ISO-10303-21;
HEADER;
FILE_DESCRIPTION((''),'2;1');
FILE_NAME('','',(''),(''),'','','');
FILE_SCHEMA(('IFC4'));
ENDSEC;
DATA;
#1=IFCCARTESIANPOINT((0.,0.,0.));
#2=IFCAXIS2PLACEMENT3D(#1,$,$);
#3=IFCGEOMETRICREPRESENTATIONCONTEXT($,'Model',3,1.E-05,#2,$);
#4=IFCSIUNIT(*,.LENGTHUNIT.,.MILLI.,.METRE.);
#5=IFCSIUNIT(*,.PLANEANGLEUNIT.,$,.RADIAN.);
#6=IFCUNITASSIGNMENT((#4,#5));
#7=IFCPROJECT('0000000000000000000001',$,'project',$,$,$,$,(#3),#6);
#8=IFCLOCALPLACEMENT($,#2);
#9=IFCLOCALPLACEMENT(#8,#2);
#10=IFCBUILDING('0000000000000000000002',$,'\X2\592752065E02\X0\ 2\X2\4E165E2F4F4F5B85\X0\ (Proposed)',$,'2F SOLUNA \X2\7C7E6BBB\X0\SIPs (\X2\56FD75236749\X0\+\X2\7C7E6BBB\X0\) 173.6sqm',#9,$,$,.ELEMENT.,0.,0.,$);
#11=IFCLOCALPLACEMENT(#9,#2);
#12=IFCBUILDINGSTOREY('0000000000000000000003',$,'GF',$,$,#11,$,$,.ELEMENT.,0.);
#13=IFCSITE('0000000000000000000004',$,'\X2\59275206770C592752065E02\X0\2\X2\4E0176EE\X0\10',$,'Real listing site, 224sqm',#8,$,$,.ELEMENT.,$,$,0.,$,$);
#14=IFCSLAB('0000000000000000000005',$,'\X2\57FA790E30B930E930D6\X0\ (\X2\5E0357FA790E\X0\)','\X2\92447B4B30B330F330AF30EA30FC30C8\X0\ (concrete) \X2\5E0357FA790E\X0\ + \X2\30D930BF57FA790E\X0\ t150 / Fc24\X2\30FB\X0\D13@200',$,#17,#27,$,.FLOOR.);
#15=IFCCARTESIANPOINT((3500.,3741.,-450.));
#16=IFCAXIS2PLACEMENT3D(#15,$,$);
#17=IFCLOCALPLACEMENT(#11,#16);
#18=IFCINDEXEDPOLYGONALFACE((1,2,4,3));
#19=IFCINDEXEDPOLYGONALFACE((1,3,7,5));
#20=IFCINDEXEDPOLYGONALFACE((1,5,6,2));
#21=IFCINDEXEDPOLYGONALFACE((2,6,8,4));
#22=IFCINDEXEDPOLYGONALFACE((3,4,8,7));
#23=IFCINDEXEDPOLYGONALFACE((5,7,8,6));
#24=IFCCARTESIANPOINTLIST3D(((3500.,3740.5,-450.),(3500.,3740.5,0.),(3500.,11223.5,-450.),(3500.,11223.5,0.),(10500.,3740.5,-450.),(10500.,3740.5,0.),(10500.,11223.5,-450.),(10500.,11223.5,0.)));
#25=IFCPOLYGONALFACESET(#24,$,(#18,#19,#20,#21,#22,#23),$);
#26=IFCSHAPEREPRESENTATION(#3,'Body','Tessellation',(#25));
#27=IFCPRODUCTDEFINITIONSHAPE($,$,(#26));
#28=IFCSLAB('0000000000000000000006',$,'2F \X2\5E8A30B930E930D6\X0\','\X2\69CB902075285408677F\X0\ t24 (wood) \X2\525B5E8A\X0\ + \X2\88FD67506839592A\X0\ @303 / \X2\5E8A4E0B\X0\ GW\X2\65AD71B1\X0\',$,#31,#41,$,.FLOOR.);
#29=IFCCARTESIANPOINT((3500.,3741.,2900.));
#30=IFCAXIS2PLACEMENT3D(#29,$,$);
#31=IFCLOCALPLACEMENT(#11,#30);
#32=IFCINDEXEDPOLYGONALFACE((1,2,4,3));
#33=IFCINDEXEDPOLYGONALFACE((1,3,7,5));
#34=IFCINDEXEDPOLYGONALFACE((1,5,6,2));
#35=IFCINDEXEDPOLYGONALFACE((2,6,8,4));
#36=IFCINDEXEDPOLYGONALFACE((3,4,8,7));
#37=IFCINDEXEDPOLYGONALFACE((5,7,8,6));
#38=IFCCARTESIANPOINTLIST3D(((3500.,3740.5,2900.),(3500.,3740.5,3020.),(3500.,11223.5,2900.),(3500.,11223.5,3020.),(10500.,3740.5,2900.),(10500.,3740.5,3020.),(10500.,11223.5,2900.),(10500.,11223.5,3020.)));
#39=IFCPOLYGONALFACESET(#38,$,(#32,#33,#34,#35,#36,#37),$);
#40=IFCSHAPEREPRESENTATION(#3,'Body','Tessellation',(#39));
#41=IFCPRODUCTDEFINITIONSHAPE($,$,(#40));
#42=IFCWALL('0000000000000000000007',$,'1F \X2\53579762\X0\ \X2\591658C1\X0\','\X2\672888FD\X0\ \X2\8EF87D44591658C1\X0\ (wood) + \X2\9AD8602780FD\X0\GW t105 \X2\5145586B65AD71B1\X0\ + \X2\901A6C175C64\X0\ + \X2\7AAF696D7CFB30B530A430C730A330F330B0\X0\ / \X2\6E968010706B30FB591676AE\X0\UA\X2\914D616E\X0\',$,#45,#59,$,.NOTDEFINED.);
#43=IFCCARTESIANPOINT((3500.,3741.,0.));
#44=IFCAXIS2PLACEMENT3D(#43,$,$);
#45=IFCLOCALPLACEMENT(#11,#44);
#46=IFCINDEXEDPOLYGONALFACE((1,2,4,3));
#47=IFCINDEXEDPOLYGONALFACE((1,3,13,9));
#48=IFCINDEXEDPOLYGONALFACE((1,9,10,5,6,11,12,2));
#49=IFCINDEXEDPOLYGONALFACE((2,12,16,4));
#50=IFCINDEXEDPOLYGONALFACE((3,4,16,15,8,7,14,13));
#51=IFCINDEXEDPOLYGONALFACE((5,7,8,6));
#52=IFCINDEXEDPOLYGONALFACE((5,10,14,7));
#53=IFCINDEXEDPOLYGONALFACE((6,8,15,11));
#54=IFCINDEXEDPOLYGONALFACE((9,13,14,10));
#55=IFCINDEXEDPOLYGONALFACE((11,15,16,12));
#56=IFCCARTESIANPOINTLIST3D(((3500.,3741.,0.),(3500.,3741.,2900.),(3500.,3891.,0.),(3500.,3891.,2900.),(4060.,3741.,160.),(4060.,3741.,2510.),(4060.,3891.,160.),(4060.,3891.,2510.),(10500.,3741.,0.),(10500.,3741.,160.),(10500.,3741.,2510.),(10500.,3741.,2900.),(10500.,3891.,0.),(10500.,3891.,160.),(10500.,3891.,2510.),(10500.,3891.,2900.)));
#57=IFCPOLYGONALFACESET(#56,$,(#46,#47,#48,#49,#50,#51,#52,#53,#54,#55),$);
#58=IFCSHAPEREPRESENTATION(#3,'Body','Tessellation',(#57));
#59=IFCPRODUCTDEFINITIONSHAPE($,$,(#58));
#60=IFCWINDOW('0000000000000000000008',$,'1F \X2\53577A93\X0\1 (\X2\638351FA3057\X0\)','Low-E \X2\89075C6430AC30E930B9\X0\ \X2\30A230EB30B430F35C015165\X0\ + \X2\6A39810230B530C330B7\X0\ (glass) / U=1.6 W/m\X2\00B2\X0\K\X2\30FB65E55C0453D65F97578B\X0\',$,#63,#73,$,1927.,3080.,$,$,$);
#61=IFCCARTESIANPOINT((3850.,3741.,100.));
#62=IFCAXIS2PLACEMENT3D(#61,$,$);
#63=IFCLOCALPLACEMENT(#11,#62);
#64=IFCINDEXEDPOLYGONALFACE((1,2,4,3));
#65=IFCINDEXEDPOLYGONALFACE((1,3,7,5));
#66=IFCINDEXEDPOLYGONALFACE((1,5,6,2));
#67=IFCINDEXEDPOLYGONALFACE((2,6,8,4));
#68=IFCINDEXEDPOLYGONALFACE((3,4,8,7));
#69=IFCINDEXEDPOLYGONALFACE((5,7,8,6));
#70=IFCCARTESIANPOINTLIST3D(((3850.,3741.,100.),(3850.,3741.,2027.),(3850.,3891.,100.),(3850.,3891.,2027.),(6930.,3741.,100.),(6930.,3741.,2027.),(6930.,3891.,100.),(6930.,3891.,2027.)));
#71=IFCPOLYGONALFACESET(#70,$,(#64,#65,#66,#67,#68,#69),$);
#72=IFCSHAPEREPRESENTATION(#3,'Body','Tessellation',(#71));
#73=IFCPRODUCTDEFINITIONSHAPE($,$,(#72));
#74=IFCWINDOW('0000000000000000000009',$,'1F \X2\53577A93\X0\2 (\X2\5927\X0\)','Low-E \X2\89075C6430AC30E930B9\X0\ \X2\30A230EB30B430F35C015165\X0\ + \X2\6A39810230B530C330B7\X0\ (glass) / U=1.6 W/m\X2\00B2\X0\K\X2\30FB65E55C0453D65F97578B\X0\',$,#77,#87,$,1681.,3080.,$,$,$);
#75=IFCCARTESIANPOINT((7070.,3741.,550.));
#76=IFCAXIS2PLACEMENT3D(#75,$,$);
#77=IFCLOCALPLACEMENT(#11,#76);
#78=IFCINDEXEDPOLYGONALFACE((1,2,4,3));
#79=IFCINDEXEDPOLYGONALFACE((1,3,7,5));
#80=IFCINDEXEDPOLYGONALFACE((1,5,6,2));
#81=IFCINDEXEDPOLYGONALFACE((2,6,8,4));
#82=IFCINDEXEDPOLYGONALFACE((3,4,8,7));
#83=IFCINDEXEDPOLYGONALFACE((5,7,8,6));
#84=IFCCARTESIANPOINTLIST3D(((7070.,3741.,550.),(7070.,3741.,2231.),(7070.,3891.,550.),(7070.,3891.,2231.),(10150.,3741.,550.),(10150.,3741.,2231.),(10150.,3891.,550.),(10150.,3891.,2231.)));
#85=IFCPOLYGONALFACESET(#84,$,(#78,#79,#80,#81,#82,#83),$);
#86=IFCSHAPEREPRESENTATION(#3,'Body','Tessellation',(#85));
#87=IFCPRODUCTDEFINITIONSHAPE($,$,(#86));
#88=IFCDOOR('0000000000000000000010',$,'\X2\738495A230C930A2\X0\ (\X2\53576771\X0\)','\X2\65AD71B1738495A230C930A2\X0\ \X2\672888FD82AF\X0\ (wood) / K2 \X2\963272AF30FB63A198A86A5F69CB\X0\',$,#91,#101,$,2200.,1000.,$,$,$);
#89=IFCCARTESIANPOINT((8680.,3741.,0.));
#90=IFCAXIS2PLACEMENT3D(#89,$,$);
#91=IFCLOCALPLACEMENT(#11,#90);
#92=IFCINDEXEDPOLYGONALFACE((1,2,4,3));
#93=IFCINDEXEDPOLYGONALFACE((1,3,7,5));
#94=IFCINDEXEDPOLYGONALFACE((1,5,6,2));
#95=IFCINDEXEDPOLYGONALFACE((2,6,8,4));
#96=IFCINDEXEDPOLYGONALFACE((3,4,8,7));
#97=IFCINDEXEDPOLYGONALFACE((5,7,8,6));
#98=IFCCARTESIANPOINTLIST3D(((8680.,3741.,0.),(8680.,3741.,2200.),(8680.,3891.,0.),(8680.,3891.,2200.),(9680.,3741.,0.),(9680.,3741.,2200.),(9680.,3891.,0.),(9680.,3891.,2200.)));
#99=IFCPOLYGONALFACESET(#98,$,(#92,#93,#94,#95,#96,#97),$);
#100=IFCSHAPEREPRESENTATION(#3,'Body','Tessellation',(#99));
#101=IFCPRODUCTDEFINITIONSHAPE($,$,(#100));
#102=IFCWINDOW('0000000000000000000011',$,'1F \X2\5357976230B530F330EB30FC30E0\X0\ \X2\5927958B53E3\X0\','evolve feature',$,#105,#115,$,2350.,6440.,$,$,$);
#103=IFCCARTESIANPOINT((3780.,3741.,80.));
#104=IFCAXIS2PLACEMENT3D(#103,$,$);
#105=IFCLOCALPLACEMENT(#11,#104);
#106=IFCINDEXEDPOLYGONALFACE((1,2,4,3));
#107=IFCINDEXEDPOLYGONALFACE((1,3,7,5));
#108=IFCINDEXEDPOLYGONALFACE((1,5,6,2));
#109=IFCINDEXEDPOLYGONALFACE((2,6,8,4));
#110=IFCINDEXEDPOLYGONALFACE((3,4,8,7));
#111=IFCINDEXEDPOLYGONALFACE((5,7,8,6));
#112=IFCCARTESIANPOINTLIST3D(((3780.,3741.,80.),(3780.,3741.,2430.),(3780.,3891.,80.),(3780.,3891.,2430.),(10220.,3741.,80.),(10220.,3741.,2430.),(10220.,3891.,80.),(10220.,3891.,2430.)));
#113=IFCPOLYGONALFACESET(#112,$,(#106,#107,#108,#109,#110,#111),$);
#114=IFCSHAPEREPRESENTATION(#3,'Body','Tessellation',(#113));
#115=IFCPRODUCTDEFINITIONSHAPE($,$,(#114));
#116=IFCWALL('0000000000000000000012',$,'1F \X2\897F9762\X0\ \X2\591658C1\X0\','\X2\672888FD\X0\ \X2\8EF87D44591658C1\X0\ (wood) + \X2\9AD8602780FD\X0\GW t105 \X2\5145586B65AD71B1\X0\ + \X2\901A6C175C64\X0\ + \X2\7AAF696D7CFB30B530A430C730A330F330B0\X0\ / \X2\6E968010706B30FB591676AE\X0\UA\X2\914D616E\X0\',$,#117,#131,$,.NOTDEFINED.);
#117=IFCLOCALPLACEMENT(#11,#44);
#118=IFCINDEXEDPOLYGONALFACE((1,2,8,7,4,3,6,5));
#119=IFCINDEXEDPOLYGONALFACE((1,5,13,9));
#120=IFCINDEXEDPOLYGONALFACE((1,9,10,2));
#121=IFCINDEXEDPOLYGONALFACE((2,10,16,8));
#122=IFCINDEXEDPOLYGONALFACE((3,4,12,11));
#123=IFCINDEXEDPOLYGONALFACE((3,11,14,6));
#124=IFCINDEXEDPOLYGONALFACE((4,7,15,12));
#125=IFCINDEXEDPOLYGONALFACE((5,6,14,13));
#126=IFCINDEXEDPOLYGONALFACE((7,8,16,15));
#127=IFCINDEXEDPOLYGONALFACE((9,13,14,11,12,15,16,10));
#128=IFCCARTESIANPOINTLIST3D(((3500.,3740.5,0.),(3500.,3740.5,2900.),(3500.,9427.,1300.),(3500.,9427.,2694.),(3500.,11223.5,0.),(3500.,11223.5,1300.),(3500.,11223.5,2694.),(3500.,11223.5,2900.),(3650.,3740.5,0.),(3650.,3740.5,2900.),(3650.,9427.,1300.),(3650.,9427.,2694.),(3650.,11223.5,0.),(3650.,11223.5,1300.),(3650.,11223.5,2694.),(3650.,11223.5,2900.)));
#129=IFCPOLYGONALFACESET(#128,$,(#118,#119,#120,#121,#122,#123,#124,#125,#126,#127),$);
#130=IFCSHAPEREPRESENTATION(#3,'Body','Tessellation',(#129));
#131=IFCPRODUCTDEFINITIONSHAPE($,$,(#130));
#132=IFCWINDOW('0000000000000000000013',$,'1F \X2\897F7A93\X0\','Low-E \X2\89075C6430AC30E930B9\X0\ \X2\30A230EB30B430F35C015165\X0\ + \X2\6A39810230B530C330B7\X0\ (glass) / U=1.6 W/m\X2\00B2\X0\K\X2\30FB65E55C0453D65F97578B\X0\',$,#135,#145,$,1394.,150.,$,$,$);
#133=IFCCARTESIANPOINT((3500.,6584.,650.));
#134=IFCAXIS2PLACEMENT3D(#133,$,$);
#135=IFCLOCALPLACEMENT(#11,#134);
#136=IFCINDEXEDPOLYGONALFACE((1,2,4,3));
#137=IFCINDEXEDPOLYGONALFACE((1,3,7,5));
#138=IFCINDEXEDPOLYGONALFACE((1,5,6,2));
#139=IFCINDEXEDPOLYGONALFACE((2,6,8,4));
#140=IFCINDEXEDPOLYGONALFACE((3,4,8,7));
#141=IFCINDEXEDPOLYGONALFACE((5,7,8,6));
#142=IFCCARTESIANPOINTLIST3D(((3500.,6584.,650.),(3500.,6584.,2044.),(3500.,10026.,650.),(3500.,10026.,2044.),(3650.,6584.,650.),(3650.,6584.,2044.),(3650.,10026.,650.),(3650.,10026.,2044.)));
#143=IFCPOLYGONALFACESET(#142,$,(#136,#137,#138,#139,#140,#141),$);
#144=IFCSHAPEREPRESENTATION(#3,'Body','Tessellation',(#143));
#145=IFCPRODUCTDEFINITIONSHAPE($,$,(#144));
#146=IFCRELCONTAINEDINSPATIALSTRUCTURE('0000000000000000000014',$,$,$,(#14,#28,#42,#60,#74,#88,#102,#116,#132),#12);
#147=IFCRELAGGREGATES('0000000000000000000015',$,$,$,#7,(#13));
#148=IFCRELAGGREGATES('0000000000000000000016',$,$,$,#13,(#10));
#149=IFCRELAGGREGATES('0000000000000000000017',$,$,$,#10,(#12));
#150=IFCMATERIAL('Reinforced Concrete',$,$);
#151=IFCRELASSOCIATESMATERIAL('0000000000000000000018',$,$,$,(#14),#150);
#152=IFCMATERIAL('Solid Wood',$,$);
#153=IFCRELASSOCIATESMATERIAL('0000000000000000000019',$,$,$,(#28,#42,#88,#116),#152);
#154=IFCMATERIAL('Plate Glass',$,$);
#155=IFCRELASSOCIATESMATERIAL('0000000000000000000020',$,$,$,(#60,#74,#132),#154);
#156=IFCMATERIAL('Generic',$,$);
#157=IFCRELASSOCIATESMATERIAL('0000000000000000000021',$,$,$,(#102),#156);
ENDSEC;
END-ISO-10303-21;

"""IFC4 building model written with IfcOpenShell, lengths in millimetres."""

from ifc_helpers import new_model, si_unit, frame, frame_2d, origin, place, context, project, spatial, rectangle, extrude, material, element, fill, save


model = new_model("IFC4")

# Units and contexts
model_context = context("Model", 3, precision=1e-05, world=origin())
ifc_project = project(units=[si_unit("LENGTHUNIT", "METRE", prefix="MILLI"), si_unit("PLANEANGLEUNIT", "RADIAN")], contexts=[model_context])

# Site, building, storey
site_placement = place(None, origin())
site = spatial("IfcSite", under=ifc_project, at=site_placement, Name="大分県大分市2丁目10", ObjectType="Real listing site, 224sqm", CompositionType="ELEMENT", RefElevation=0.0)
building_placement = place(site_placement, origin())
building = spatial("IfcBuilding", under=site, at=building_placement, Name="大分市 2世帯住宅 (Proposed)", ObjectType="2F SOLUNA 籾殻SIPs (国産杉+籾殻) 173.6sqm", CompositionType="ELEMENT", ElevationOfRefHeight=0.0, ElevationOfTerrain=0.0)
storey_placement = place(building_placement, origin())
storey = spatial("IfcBuildingStorey", under=building, at=storey_placement, Name="GF", CompositionType="ELEMENT", Elevation=0.0)

# Slabs
ifc_material_1 = material(Name="Reinforced Concrete")
slab_1_placement = place(storey_placement, frame((3500.0, 3741.0, -450.0)))
element("IfcSlab", 1, at=slab_1_placement, inside=storey, material=ifc_material_1, Name="基礎スラブ (布基礎)", Description="鉄筋コンクリート (concrete) 布基礎 + ベタ基礎 t150 / Fc24・D13@200", PredefinedType="FLOOR", context=model_context, shape_type="SweptSolid", body=[
    extrude(rectangle(XDim=7000.0, YDim=7483.0, at=frame_2d((3500.0, 3741.0))), frame((3500.0, 3741.0, -450.0)), (0.0, 0.0, 1.0), 450.0),
])
ifc_material_2 = material(Name="Solid Wood")
slab_2_placement = place(storey_placement, frame((3500.0, 3741.0, 2900.0)))
element("IfcSlab", 2, at=slab_2_placement, inside=storey, material=ifc_material_2, Name="2F 床スラブ", Description="構造用合板 t24 (wood) 剛床 + 製材根太 @303 / 床下 GW断熱", PredefinedType="FLOOR", context=model_context, shape_type="SweptSolid", body=[
    extrude(rectangle(XDim=7000.0, YDim=7483.0, at=frame_2d((3500.0, 3741.0))), frame((3500.0, 3741.0, 2900.0)), (0.0, 0.0, 1.0), 120.0),
])
ifc_material_3 = material(Name="Generic")

# Wall, openings, windows, door
wall_1_placement = place(storey_placement, frame((3500.0, 3741.0, 0.0)))
wall_1 = element("IfcWall", 3, at=wall_1_placement, inside=storey, material=ifc_material_2, Name="1F 南面 外壁", Description="木製 軸組外壁 (wood) + 高性能GW t105 充填断熱 + 通気層 + 窯業系サイディング / 準耐火・外皮UA配慮", PredefinedType="NOTDEFINED", context=model_context, shape_type="SweptSolid", body=[
    extrude(rectangle(XDim=7000.0, YDim=150.0, at=frame_2d((3500.0, 75.0))), frame((3500.0, 3741.0, 0.0)), (0.0, 0.0, 1.0), 2900.0),
])
opening_1_placement = place(storey_placement, frame((3850.0, 3741.0, 100.0)))
opening_1 = element("IfcOpeningElement", 4, at=opening_1_placement, cuts=wall_1, PredefinedType="NOTDEFINED", context=model_context, shape_type="SweptSolid", body=[
    extrude(rectangle(XDim=3080.0, YDim=150.0, at=frame_2d((1540.0, 75.0))), frame((3850.0, 3741.0, 100.0)), (0.0, 0.0, 1.0), 1927.0),
])
opening_2_placement = place(storey_placement, frame((7070.0, 3741.0, 550.0)))
opening_2 = element("IfcOpeningElement", 5, at=opening_2_placement, cuts=wall_1, PredefinedType="NOTDEFINED", context=model_context, shape_type="SweptSolid", body=[
    extrude(rectangle(XDim=3080.0, YDim=150.0, at=frame_2d((1540.0, 75.0))), frame((7070.0, 3741.0, 550.0)), (0.0, 0.0, 1.0), 1681.0),
])
opening_3_placement = place(storey_placement, frame((8680.0, 3741.0, 0.0)))
opening_3 = element("IfcOpeningElement", 6, at=opening_3_placement, cuts=wall_1, PredefinedType="NOTDEFINED", context=model_context, shape_type="SweptSolid", body=[
    extrude(rectangle(XDim=1000.0, YDim=150.0, at=frame_2d((500.0, 75.0))), frame((8680.0, 3741.0, 0.0)), (0.0, 0.0, 1.0), 2200.0),
])
opening_4_placement = place(storey_placement, frame((3780.0, 3741.0, 80.0)))
opening_4 = element("IfcOpeningElement", 7, at=opening_4_placement, cuts=wall_1, PredefinedType="NOTDEFINED", context=model_context, shape_type="SweptSolid", body=[
    extrude(rectangle(XDim=6440.0, YDim=150.0, at=frame_2d((3220.0, 75.0))), frame((3780.0, 3741.0, 80.0)), (0.0, 0.0, 1.0), 2350.0),
])
ifc_material_4 = material(Name="Plate Glass")
window_1_placement = place(storey_placement, frame((3850.0, 3741.0, 100.0)))
window_1 = element("IfcWindow", 8, at=window_1_placement, inside=storey, material=ifc_material_4, Name="1F 南窓1 (掃出し)", Description="Low-E 複層ガラス アルゴン封入 + 樹脂サッシ (glass) / U=1.6 W/m²K・日射取得型", OverallHeight=1927.0, OverallWidth=3080.0, context=model_context, shape_type="SweptSolid", body=[
    extrude(rectangle(XDim=3080.0, YDim=150.0, at=frame_2d((1540.0, 75.0))), frame((3850.0, 3741.0, 100.0)), (0.0, 0.0, 1.0), 1927.0),
])
fill(opening_1, window_1)
window_2_placement = place(storey_placement, frame((7070.0, 3741.0, 550.0)))
window_2 = element("IfcWindow", 9, at=window_2_placement, inside=storey, material=ifc_material_4, Name="1F 南窓2 (大)", Description="Low-E 複層ガラス アルゴン封入 + 樹脂サッシ (glass) / U=1.6 W/m²K・日射取得型", OverallHeight=1681.0, OverallWidth=3080.0, context=model_context, shape_type="SweptSolid", body=[
    extrude(rectangle(XDim=3080.0, YDim=150.0, at=frame_2d((1540.0, 75.0))), frame((7070.0, 3741.0, 550.0)), (0.0, 0.0, 1.0), 1681.0),
])
fill(opening_2, window_2)
door_placement = place(storey_placement, frame((8680.0, 3741.0, 0.0)))
door = element("IfcDoor", 10, at=door_placement, inside=storey, material=ifc_material_2, Name="玄関ドア (南東)", Description="断熱玄関ドア 木製芯 (wood) / K2 防犯・採風機構", OverallHeight=2200.0, OverallWidth=1000.0, context=model_context, shape_type="SweptSolid", body=[
    extrude(rectangle(XDim=1000.0, YDim=150.0, at=frame_2d((500.0, 75.0))), frame((8680.0, 3741.0, 0.0)), (0.0, 0.0, 1.0), 2200.0),
])
fill(opening_3, door)
window_3_placement = place(storey_placement, frame((3780.0, 3741.0, 80.0)))
window_3 = element("IfcWindow", 11, at=window_3_placement, inside=storey, material=ifc_material_3, Name="1F 南面サンルーム 大開口", Description="evolve feature", OverallHeight=2350.0, OverallWidth=6440.0, context=model_context, shape_type="SweptSolid", body=[
    extrude(rectangle(XDim=6440.0, YDim=150.0, at=frame_2d((3220.0, 75.0))), frame((3780.0, 3741.0, 80.0)), (0.0, 0.0, 1.0), 2350.0),
])
fill(opening_4, window_3)

# Wall, opening, window
wall_2_placement = place(storey_placement, frame((3500.0, 3741.0, 0.0)))
wall_2 = element("IfcWall", 12, at=wall_2_placement, inside=storey, material=ifc_material_2, Name="1F 西面 外壁", Description="木製 軸組外壁 (wood) + 高性能GW t105 充填断熱 + 通気層 + 窯業系サイディング / 準耐火・外皮UA配慮", PredefinedType="NOTDEFINED", context=model_context, shape_type="SweptSolid", body=[
    extrude(rectangle(XDim=150.0, YDim=7483.0, at=frame_2d((75.0, 3741.0))), frame((3500.0, 3741.0, 0.0)), (0.0, 0.0, 1.0), 2900.0),
])
opening_5_placement = place(storey_placement, frame((3500.0, 6584.0, 650.0)))
opening_5 = element("IfcOpeningElement", 13, at=opening_5_placement, cuts=wall_2, PredefinedType="NOTDEFINED", context=model_context, shape_type="SweptSolid", body=[
    extrude(rectangle(XDim=150.0, YDim=3442.0, at=frame_2d((75.0, 1721.0))), frame((3500.0, 6584.0, 650.0)), (0.0, 0.0, 1.0), 1394.0),
])
window_4_placement = place(storey_placement, frame((3500.0, 6584.0, 650.0)))
window_4 = element("IfcWindow", 14, at=window_4_placement, inside=storey, material=ifc_material_4, Name="1F 西窓", Description="Low-E 複層ガラス アルゴン封入 + 樹脂サッシ (glass) / U=1.6 W/m²K・日射取得型", OverallHeight=1394.0, OverallWidth=150.0, context=model_context, shape_type="SweptSolid", body=[
    extrude(rectangle(XDim=150.0, YDim=3442.0, at=frame_2d((75.0, 1721.0))), frame((3500.0, 6584.0, 650.0)), (0.0, 0.0, 1.0), 1394.0),
])
fill(opening_5, window_4)

save(model, "model.ifc")
